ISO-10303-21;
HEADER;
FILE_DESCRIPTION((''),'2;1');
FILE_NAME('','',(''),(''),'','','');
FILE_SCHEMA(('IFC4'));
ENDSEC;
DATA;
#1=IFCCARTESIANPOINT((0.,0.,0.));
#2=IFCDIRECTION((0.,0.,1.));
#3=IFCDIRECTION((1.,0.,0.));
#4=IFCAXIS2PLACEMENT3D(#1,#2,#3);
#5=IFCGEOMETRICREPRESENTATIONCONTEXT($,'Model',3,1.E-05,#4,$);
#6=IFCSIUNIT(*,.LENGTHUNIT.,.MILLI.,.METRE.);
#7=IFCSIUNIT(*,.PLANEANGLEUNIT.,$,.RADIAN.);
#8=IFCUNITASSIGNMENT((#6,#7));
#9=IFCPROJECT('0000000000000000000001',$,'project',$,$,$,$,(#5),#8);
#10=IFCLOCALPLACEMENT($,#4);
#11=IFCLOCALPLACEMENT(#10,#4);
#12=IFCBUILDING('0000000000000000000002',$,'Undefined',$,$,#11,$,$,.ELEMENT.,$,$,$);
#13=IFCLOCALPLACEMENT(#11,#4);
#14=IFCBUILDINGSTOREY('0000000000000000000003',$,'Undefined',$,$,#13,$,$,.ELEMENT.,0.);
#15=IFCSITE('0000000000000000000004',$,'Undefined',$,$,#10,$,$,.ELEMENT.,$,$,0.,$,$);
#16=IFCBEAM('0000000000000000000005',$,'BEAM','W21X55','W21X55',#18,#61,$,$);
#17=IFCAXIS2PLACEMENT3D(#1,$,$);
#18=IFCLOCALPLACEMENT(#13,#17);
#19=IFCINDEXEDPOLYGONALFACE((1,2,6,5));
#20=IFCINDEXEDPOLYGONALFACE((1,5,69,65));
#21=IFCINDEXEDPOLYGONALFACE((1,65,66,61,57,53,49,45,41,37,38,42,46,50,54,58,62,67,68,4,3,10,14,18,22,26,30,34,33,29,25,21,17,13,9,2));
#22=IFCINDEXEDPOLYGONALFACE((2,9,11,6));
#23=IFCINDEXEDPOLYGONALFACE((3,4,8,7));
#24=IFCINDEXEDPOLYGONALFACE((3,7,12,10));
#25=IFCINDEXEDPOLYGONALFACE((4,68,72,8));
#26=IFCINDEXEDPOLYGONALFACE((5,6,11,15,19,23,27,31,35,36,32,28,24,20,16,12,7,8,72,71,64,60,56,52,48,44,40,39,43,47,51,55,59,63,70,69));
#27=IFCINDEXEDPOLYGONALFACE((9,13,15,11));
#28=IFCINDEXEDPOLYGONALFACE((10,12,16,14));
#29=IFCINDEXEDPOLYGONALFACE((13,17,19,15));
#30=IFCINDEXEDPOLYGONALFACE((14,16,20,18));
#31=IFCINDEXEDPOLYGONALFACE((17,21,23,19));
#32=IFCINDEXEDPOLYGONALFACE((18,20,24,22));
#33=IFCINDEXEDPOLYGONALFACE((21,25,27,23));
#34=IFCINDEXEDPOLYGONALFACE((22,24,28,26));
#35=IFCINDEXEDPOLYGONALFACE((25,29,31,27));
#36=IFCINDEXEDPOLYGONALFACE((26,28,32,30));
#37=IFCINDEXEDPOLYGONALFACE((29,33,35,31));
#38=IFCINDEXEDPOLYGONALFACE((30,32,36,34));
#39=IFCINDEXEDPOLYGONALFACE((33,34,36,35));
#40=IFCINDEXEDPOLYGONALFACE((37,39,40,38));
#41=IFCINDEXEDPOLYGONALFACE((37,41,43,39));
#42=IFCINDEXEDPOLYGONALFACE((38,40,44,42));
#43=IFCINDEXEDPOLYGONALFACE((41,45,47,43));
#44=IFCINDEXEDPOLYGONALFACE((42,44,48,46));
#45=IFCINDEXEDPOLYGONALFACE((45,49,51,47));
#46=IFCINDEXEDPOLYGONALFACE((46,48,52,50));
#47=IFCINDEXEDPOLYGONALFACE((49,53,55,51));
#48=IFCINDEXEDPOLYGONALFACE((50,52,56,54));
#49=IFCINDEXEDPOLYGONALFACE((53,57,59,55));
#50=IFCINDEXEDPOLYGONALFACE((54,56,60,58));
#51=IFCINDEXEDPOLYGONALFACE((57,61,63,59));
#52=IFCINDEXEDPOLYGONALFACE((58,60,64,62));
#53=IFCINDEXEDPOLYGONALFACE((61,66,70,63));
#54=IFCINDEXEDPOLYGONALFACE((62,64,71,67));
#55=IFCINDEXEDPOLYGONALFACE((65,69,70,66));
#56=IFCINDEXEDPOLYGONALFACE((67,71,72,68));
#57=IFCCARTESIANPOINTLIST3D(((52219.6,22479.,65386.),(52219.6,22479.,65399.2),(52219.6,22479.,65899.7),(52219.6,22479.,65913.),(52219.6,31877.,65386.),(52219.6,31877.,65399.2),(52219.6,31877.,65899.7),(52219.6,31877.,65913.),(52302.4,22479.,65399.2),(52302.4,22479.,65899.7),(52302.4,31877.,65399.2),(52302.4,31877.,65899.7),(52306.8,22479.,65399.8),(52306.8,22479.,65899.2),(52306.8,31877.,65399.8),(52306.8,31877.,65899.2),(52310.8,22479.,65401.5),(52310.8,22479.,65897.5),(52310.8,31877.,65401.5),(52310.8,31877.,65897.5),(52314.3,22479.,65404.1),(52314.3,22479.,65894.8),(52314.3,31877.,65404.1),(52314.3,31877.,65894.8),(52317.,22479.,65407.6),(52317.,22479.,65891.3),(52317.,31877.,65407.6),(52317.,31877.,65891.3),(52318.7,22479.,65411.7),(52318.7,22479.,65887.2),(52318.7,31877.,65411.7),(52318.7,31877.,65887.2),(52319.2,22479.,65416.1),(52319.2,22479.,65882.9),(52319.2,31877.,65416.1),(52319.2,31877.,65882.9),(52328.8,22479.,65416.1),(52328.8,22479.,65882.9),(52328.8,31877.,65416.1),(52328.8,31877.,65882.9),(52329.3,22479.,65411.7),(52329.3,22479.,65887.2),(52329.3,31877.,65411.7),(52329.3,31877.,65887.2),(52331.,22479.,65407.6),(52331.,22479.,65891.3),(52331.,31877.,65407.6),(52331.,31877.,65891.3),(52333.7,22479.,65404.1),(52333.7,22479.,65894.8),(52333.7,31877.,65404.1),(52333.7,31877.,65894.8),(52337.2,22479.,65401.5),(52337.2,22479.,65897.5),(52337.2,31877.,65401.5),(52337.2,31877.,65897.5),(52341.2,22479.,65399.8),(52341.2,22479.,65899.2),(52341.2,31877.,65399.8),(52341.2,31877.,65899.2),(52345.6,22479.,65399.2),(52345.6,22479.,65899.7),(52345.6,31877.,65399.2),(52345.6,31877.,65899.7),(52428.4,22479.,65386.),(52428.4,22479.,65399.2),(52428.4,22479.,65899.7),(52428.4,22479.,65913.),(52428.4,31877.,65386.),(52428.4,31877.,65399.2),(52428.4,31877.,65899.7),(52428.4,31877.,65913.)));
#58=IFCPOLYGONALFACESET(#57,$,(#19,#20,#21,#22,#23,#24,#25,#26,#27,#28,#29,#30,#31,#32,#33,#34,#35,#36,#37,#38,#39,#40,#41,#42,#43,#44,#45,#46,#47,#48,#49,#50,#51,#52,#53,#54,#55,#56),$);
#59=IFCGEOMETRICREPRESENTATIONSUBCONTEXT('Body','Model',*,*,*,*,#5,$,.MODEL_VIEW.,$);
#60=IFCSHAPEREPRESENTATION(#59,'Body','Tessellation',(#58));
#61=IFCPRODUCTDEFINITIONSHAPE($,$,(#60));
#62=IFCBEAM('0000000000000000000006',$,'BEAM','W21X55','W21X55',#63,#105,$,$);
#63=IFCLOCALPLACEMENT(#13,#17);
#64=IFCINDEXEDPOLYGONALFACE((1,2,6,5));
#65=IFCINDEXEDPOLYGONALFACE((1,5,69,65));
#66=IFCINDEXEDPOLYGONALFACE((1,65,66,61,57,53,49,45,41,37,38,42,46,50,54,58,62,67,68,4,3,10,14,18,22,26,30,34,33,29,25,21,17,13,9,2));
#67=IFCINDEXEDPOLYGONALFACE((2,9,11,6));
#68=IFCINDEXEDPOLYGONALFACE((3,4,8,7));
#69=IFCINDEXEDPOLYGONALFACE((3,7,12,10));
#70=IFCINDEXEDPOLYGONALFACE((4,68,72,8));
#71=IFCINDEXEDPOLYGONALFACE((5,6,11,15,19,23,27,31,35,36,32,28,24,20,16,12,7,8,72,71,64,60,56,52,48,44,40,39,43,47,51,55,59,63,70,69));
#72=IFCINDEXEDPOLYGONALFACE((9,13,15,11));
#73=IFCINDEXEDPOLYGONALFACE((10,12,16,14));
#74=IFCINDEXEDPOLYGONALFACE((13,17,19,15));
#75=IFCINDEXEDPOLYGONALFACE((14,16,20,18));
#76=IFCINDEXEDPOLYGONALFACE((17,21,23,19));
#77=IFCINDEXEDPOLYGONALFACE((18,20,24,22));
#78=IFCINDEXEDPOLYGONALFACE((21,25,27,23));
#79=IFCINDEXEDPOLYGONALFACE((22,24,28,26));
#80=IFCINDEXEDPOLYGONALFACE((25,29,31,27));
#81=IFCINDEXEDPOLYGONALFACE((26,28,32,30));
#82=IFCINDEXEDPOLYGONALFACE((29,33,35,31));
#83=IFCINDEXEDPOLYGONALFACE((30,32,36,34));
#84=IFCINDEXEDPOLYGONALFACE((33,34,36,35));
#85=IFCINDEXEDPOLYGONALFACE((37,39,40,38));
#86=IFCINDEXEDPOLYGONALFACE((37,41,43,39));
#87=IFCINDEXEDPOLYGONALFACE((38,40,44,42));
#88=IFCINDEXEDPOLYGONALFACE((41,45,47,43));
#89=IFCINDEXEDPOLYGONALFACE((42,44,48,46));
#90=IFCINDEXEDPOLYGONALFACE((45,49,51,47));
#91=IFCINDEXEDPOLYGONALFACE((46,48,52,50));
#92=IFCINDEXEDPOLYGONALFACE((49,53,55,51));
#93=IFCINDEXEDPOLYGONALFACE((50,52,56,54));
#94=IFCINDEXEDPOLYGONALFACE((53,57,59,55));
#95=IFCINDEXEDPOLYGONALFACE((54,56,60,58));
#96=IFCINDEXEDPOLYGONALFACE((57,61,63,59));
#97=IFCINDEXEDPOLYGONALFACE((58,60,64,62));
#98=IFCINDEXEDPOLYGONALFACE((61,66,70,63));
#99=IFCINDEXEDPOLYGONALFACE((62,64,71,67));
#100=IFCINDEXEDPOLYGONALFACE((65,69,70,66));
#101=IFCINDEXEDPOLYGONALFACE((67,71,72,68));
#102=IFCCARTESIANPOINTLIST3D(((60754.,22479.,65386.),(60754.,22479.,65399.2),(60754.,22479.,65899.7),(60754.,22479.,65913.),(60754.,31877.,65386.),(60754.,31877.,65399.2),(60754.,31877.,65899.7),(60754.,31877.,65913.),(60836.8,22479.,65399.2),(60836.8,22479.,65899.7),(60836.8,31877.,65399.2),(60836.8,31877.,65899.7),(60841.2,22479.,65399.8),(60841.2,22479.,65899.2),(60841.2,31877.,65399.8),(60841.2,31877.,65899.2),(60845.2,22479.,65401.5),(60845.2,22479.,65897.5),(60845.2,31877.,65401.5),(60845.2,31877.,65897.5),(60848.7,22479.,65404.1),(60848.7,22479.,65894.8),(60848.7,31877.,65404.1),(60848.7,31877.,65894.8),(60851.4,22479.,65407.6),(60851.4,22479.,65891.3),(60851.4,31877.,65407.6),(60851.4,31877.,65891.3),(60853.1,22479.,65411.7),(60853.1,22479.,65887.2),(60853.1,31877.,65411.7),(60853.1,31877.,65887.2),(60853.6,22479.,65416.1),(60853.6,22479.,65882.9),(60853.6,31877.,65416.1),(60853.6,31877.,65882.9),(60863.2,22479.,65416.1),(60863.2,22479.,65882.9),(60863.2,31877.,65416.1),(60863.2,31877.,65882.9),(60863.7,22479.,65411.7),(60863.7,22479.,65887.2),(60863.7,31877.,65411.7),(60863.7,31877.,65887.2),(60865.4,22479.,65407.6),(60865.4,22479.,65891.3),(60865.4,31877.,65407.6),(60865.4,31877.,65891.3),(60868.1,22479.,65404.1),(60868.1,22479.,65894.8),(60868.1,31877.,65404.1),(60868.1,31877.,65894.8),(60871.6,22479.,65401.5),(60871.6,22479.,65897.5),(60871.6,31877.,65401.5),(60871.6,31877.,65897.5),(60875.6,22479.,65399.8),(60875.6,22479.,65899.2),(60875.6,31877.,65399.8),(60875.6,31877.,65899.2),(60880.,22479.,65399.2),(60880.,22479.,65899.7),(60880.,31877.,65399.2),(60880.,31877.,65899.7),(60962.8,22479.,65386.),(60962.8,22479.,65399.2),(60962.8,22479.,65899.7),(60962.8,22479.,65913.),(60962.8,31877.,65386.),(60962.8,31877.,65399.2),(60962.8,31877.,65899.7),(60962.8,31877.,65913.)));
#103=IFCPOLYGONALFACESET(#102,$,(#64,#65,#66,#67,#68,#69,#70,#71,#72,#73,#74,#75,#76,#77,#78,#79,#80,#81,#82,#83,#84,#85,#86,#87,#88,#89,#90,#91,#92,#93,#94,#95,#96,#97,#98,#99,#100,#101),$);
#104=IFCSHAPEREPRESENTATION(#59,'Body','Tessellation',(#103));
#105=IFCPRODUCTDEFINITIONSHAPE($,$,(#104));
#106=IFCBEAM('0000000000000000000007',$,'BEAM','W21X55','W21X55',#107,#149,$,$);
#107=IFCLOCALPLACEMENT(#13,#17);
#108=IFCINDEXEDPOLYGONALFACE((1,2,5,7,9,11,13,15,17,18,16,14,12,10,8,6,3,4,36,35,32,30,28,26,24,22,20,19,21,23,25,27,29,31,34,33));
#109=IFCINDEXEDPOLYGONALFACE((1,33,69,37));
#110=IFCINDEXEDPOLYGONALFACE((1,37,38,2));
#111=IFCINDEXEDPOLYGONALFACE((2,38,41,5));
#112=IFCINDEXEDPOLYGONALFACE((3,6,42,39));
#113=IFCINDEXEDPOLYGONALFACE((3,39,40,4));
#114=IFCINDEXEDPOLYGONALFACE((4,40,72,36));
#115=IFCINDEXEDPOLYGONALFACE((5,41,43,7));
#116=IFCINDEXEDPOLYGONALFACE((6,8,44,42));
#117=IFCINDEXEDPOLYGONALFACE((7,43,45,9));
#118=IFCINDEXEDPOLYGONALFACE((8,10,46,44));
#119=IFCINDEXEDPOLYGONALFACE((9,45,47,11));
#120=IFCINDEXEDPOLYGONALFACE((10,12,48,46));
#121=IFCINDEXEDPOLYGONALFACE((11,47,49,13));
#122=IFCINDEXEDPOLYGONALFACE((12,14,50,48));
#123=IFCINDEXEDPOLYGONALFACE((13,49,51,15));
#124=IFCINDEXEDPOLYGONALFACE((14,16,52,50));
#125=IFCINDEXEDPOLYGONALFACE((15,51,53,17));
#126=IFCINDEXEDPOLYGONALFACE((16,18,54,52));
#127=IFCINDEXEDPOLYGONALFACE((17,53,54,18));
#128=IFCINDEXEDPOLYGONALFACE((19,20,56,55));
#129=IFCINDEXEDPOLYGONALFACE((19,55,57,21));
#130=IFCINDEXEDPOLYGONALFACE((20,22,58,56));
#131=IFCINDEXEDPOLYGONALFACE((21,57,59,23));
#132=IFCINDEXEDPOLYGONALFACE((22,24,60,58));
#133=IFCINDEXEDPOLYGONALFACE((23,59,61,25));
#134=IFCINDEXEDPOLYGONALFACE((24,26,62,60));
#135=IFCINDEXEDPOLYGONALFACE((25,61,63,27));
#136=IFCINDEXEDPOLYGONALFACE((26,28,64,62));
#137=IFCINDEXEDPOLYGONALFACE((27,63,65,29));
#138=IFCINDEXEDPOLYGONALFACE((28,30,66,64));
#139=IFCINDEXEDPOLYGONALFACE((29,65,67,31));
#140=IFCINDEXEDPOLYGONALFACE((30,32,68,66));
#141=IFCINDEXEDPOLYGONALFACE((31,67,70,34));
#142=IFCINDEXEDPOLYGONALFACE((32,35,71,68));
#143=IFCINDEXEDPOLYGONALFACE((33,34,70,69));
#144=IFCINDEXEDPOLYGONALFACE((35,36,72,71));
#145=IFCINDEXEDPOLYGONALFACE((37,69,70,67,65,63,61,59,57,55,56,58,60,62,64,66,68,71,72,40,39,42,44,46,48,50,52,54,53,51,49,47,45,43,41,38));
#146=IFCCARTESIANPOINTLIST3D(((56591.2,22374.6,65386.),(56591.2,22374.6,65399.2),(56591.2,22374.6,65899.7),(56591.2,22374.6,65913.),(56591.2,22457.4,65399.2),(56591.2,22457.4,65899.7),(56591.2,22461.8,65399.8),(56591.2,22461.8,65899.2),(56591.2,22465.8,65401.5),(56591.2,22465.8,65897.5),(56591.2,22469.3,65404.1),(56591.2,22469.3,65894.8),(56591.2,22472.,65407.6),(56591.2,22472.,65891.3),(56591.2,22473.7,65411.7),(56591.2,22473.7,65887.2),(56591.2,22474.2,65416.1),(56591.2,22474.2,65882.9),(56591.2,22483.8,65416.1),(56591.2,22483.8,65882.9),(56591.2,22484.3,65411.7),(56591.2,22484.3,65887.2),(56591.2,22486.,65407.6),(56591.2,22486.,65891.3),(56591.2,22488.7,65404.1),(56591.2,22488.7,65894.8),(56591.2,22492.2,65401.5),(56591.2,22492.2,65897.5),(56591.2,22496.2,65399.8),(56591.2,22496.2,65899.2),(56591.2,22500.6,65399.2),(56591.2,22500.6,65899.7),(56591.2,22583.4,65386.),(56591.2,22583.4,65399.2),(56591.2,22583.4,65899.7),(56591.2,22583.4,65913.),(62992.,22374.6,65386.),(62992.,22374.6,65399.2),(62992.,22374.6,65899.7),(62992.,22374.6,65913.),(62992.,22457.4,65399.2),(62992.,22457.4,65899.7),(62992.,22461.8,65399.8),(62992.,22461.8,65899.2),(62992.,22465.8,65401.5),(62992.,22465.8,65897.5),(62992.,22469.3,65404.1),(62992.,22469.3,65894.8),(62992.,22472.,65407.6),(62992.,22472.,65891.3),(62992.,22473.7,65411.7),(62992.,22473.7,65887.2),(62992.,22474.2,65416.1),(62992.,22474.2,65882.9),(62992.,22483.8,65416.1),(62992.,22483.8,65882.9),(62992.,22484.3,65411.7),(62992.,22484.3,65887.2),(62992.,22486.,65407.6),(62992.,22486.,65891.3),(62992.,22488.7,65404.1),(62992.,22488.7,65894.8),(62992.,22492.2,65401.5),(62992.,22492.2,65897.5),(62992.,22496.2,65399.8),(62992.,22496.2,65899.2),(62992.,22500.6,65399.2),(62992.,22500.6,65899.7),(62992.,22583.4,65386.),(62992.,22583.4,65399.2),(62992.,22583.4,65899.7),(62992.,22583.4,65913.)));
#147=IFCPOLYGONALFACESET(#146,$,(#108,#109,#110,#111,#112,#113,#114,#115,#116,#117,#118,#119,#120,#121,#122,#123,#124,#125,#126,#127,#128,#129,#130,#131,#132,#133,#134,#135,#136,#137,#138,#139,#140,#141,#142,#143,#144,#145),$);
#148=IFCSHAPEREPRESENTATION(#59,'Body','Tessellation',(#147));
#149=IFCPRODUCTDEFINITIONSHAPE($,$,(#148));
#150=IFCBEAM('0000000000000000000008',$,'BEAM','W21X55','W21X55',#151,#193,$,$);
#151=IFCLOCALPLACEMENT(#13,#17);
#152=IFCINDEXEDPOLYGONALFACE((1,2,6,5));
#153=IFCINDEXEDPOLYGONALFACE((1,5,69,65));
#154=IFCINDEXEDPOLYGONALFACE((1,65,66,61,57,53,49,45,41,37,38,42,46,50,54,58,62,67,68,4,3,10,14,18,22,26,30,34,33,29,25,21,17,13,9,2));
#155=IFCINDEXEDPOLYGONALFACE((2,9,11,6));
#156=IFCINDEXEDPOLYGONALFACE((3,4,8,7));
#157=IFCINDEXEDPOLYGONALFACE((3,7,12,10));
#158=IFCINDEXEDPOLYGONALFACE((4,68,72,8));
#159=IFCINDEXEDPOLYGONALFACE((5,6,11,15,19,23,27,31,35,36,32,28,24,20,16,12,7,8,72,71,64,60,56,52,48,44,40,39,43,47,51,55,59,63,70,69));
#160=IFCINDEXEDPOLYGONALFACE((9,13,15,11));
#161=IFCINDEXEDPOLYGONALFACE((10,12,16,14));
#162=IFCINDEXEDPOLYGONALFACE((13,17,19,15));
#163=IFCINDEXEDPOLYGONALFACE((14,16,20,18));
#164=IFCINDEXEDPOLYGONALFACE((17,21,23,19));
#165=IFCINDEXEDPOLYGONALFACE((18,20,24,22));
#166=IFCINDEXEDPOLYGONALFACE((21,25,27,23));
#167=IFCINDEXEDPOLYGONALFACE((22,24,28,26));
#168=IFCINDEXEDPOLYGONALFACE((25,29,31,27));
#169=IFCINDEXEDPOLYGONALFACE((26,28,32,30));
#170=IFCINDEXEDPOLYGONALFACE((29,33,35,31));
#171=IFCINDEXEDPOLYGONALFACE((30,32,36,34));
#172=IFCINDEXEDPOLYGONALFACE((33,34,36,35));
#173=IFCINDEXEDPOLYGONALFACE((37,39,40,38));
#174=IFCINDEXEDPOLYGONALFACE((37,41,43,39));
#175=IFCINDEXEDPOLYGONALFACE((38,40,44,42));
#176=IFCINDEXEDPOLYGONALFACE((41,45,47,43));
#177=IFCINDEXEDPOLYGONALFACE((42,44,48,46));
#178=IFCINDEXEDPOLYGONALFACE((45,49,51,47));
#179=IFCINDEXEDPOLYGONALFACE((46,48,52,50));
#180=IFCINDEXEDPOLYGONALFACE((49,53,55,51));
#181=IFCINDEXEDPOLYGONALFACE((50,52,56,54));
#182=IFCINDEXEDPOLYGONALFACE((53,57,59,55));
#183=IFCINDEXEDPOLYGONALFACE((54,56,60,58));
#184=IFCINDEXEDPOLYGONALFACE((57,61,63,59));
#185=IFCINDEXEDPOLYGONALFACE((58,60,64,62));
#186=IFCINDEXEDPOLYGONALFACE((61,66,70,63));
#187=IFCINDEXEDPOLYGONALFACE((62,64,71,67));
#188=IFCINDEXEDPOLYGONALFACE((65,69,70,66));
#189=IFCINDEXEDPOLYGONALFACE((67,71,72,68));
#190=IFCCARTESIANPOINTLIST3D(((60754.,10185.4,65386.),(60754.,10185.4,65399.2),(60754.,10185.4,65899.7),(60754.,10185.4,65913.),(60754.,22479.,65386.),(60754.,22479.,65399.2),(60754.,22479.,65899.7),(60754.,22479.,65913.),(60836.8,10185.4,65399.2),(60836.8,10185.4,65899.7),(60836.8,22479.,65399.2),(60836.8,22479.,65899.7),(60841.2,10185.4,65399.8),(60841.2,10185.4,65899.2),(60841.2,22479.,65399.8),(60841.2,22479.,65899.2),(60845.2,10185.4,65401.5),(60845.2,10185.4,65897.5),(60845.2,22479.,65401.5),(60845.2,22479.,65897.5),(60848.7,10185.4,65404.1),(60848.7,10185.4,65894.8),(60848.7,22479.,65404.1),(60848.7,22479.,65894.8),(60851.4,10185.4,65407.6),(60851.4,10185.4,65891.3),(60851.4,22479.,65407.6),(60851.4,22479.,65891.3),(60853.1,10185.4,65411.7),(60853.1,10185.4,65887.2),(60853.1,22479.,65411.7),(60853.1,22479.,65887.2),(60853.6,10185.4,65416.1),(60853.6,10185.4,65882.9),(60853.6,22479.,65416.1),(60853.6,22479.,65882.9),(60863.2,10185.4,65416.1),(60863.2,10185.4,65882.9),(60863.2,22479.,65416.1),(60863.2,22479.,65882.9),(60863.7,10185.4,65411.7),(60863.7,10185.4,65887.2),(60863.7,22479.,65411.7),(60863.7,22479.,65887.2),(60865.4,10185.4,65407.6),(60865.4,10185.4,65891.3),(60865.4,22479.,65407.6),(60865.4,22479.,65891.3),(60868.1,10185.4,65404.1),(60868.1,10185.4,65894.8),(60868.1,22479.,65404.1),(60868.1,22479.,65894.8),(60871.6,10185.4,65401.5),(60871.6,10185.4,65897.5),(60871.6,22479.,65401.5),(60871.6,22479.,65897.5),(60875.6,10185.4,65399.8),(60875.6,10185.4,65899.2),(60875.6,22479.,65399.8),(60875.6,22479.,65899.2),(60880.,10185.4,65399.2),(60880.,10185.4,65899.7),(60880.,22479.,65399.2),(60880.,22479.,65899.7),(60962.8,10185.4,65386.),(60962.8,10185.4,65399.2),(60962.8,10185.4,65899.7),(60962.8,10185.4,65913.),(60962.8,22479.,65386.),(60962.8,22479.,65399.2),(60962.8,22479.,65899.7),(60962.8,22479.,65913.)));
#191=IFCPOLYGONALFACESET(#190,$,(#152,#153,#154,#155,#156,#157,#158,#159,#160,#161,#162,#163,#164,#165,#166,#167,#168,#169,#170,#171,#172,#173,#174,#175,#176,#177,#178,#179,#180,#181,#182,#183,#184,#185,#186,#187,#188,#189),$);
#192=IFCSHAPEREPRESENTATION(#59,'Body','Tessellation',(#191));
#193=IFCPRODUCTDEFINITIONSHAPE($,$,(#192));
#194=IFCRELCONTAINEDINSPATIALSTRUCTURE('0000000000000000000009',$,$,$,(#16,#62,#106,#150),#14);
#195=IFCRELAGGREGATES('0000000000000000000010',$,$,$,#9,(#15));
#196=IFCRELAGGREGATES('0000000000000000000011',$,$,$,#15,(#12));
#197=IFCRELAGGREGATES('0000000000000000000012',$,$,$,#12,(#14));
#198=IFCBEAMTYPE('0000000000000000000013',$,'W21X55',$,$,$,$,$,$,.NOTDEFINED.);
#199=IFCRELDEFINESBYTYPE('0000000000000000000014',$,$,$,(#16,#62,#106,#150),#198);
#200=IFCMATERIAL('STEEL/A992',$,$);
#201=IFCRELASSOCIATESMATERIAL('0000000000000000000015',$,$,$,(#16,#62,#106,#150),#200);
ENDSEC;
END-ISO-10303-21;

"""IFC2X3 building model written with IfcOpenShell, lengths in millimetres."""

from ifc_helpers import new_model, si_unit, frame, origin_with_axes, origin_2d_with_axis, place, context, subcontext, project, spatial, i_section, extrude, material, type_object, element, save


model = new_model("IFC2X3")

# Units and contexts
model_context = context("Model", 3, precision=1e-05, world=origin_with_axes())
body_context = subcontext(model_context, "Body", "Model", "MODEL_VIEW")
ifc_project = project(units=[si_unit("LENGTHUNIT", "METRE", prefix="MILLI"), si_unit("PLANEANGLEUNIT", "RADIAN")], contexts=[model_context])

# Site, building, storey
site_placement = place(None, origin_with_axes())
site = spatial("IfcSite", under=ifc_project, at=site_placement, Name="Undefined", CompositionType="ELEMENT", RefElevation=0.0)
building_placement = place(site_placement, origin_with_axes())
building = spatial("IfcBuilding", under=site, at=building_placement, Name="Undefined", CompositionType="ELEMENT")
storey_placement = place(building_placement, origin_with_axes())
storey = spatial("IfcBuildingStorey", under=building, at=storey_placement, Name="Undefined", CompositionType="ELEMENT", Elevation=0.0)

# Shared definitions
ifc_material_1 = material(Name="STEEL/A992")

# Beams
beam_type_1 = type_object("IfcBeamType", Name="W21X55", PredefinedType="NOTDEFINED")
for number, where, z_axis, x_axis, name in (
    (1, (52324.0, 22479.0, 65649.5), (0.0, 0.0, 1.0), (0.0, 1.0, 0.0), "BEAM"),
    (2, (60858.4, 22479.0, 65649.5), (0.0, 0.0, 1.0), (0.0, 1.0, 0.0), "BEAM"),
):
    element("IfcBeam", number, at=place(storey_placement, frame(where, z_axis=z_axis, x_axis=x_axis)), inside=storey, type_object=beam_type_1, material=ifc_material_1, Name=name, Description="W21X55", ObjectType="W21X55", context=body_context, shape_type="SweptSolid", body=[
        extrude(i_section(OverallWidth=208.8, OverallDepth=527.0, WebThickness=9.5, FlangeThickness=13.3, FilletRadius=16.9, at=origin_2d_with_axis()), frame((9398.0, 0.0, 0.0), z_axis=(-1.0, 0.0, 0.0), x_axis=(0.0, -1.0, 0.0)), (0.0, 0.0, 1.0), 9398.0),
    ])
beam_1_placement = place(storey_placement, frame((56591.2, 22479.0, 65649.5), z_axis=(0.0, 0.0, 1.0), x_axis=(1.0, 0.0, 0.0)))
element("IfcBeam", 3, at=beam_1_placement, inside=storey, type_object=beam_type_1, material=ifc_material_1, Name="BEAM", Description="W21X55", ObjectType="W21X55", context=body_context, shape_type="SweptSolid", body=[
    extrude(i_section(OverallWidth=208.8, OverallDepth=527.0, WebThickness=9.5, FlangeThickness=13.3, FilletRadius=16.9, at=origin_2d_with_axis()), frame((6400.8, 0.0, 0.0), z_axis=(-1.0, 0.0, 0.0), x_axis=(0.0, -1.0, 0.0)), (0.0, 0.0, 1.0), 6400.8),
])
for number, where, z_axis, x_axis, name in (
    (4, (60858.4, 10185.4, 65649.5), (0.0, 0.0, 1.0), (0.0, 1.0, 0.0), "BEAM"),
):
    element("IfcBeam", number, at=place(storey_placement, frame(where, z_axis=z_axis, x_axis=x_axis)), inside=storey, type_object=beam_type_1, material=ifc_material_1, Name=name, Description="W21X55", ObjectType="W21X55", context=body_context, shape_type="SweptSolid", body=[
        extrude(i_section(OverallWidth=208.8, OverallDepth=527.0, WebThickness=9.5, FlangeThickness=13.3, FilletRadius=16.9, at=origin_2d_with_axis()), frame((12293.6, 0.0, 0.0), z_axis=(-1.0, 0.0, 0.0), x_axis=(0.0, -1.0, 0.0)), (0.0, 0.0, 1.0), 12293.6),
    ])

save(model, "model.ifc")
